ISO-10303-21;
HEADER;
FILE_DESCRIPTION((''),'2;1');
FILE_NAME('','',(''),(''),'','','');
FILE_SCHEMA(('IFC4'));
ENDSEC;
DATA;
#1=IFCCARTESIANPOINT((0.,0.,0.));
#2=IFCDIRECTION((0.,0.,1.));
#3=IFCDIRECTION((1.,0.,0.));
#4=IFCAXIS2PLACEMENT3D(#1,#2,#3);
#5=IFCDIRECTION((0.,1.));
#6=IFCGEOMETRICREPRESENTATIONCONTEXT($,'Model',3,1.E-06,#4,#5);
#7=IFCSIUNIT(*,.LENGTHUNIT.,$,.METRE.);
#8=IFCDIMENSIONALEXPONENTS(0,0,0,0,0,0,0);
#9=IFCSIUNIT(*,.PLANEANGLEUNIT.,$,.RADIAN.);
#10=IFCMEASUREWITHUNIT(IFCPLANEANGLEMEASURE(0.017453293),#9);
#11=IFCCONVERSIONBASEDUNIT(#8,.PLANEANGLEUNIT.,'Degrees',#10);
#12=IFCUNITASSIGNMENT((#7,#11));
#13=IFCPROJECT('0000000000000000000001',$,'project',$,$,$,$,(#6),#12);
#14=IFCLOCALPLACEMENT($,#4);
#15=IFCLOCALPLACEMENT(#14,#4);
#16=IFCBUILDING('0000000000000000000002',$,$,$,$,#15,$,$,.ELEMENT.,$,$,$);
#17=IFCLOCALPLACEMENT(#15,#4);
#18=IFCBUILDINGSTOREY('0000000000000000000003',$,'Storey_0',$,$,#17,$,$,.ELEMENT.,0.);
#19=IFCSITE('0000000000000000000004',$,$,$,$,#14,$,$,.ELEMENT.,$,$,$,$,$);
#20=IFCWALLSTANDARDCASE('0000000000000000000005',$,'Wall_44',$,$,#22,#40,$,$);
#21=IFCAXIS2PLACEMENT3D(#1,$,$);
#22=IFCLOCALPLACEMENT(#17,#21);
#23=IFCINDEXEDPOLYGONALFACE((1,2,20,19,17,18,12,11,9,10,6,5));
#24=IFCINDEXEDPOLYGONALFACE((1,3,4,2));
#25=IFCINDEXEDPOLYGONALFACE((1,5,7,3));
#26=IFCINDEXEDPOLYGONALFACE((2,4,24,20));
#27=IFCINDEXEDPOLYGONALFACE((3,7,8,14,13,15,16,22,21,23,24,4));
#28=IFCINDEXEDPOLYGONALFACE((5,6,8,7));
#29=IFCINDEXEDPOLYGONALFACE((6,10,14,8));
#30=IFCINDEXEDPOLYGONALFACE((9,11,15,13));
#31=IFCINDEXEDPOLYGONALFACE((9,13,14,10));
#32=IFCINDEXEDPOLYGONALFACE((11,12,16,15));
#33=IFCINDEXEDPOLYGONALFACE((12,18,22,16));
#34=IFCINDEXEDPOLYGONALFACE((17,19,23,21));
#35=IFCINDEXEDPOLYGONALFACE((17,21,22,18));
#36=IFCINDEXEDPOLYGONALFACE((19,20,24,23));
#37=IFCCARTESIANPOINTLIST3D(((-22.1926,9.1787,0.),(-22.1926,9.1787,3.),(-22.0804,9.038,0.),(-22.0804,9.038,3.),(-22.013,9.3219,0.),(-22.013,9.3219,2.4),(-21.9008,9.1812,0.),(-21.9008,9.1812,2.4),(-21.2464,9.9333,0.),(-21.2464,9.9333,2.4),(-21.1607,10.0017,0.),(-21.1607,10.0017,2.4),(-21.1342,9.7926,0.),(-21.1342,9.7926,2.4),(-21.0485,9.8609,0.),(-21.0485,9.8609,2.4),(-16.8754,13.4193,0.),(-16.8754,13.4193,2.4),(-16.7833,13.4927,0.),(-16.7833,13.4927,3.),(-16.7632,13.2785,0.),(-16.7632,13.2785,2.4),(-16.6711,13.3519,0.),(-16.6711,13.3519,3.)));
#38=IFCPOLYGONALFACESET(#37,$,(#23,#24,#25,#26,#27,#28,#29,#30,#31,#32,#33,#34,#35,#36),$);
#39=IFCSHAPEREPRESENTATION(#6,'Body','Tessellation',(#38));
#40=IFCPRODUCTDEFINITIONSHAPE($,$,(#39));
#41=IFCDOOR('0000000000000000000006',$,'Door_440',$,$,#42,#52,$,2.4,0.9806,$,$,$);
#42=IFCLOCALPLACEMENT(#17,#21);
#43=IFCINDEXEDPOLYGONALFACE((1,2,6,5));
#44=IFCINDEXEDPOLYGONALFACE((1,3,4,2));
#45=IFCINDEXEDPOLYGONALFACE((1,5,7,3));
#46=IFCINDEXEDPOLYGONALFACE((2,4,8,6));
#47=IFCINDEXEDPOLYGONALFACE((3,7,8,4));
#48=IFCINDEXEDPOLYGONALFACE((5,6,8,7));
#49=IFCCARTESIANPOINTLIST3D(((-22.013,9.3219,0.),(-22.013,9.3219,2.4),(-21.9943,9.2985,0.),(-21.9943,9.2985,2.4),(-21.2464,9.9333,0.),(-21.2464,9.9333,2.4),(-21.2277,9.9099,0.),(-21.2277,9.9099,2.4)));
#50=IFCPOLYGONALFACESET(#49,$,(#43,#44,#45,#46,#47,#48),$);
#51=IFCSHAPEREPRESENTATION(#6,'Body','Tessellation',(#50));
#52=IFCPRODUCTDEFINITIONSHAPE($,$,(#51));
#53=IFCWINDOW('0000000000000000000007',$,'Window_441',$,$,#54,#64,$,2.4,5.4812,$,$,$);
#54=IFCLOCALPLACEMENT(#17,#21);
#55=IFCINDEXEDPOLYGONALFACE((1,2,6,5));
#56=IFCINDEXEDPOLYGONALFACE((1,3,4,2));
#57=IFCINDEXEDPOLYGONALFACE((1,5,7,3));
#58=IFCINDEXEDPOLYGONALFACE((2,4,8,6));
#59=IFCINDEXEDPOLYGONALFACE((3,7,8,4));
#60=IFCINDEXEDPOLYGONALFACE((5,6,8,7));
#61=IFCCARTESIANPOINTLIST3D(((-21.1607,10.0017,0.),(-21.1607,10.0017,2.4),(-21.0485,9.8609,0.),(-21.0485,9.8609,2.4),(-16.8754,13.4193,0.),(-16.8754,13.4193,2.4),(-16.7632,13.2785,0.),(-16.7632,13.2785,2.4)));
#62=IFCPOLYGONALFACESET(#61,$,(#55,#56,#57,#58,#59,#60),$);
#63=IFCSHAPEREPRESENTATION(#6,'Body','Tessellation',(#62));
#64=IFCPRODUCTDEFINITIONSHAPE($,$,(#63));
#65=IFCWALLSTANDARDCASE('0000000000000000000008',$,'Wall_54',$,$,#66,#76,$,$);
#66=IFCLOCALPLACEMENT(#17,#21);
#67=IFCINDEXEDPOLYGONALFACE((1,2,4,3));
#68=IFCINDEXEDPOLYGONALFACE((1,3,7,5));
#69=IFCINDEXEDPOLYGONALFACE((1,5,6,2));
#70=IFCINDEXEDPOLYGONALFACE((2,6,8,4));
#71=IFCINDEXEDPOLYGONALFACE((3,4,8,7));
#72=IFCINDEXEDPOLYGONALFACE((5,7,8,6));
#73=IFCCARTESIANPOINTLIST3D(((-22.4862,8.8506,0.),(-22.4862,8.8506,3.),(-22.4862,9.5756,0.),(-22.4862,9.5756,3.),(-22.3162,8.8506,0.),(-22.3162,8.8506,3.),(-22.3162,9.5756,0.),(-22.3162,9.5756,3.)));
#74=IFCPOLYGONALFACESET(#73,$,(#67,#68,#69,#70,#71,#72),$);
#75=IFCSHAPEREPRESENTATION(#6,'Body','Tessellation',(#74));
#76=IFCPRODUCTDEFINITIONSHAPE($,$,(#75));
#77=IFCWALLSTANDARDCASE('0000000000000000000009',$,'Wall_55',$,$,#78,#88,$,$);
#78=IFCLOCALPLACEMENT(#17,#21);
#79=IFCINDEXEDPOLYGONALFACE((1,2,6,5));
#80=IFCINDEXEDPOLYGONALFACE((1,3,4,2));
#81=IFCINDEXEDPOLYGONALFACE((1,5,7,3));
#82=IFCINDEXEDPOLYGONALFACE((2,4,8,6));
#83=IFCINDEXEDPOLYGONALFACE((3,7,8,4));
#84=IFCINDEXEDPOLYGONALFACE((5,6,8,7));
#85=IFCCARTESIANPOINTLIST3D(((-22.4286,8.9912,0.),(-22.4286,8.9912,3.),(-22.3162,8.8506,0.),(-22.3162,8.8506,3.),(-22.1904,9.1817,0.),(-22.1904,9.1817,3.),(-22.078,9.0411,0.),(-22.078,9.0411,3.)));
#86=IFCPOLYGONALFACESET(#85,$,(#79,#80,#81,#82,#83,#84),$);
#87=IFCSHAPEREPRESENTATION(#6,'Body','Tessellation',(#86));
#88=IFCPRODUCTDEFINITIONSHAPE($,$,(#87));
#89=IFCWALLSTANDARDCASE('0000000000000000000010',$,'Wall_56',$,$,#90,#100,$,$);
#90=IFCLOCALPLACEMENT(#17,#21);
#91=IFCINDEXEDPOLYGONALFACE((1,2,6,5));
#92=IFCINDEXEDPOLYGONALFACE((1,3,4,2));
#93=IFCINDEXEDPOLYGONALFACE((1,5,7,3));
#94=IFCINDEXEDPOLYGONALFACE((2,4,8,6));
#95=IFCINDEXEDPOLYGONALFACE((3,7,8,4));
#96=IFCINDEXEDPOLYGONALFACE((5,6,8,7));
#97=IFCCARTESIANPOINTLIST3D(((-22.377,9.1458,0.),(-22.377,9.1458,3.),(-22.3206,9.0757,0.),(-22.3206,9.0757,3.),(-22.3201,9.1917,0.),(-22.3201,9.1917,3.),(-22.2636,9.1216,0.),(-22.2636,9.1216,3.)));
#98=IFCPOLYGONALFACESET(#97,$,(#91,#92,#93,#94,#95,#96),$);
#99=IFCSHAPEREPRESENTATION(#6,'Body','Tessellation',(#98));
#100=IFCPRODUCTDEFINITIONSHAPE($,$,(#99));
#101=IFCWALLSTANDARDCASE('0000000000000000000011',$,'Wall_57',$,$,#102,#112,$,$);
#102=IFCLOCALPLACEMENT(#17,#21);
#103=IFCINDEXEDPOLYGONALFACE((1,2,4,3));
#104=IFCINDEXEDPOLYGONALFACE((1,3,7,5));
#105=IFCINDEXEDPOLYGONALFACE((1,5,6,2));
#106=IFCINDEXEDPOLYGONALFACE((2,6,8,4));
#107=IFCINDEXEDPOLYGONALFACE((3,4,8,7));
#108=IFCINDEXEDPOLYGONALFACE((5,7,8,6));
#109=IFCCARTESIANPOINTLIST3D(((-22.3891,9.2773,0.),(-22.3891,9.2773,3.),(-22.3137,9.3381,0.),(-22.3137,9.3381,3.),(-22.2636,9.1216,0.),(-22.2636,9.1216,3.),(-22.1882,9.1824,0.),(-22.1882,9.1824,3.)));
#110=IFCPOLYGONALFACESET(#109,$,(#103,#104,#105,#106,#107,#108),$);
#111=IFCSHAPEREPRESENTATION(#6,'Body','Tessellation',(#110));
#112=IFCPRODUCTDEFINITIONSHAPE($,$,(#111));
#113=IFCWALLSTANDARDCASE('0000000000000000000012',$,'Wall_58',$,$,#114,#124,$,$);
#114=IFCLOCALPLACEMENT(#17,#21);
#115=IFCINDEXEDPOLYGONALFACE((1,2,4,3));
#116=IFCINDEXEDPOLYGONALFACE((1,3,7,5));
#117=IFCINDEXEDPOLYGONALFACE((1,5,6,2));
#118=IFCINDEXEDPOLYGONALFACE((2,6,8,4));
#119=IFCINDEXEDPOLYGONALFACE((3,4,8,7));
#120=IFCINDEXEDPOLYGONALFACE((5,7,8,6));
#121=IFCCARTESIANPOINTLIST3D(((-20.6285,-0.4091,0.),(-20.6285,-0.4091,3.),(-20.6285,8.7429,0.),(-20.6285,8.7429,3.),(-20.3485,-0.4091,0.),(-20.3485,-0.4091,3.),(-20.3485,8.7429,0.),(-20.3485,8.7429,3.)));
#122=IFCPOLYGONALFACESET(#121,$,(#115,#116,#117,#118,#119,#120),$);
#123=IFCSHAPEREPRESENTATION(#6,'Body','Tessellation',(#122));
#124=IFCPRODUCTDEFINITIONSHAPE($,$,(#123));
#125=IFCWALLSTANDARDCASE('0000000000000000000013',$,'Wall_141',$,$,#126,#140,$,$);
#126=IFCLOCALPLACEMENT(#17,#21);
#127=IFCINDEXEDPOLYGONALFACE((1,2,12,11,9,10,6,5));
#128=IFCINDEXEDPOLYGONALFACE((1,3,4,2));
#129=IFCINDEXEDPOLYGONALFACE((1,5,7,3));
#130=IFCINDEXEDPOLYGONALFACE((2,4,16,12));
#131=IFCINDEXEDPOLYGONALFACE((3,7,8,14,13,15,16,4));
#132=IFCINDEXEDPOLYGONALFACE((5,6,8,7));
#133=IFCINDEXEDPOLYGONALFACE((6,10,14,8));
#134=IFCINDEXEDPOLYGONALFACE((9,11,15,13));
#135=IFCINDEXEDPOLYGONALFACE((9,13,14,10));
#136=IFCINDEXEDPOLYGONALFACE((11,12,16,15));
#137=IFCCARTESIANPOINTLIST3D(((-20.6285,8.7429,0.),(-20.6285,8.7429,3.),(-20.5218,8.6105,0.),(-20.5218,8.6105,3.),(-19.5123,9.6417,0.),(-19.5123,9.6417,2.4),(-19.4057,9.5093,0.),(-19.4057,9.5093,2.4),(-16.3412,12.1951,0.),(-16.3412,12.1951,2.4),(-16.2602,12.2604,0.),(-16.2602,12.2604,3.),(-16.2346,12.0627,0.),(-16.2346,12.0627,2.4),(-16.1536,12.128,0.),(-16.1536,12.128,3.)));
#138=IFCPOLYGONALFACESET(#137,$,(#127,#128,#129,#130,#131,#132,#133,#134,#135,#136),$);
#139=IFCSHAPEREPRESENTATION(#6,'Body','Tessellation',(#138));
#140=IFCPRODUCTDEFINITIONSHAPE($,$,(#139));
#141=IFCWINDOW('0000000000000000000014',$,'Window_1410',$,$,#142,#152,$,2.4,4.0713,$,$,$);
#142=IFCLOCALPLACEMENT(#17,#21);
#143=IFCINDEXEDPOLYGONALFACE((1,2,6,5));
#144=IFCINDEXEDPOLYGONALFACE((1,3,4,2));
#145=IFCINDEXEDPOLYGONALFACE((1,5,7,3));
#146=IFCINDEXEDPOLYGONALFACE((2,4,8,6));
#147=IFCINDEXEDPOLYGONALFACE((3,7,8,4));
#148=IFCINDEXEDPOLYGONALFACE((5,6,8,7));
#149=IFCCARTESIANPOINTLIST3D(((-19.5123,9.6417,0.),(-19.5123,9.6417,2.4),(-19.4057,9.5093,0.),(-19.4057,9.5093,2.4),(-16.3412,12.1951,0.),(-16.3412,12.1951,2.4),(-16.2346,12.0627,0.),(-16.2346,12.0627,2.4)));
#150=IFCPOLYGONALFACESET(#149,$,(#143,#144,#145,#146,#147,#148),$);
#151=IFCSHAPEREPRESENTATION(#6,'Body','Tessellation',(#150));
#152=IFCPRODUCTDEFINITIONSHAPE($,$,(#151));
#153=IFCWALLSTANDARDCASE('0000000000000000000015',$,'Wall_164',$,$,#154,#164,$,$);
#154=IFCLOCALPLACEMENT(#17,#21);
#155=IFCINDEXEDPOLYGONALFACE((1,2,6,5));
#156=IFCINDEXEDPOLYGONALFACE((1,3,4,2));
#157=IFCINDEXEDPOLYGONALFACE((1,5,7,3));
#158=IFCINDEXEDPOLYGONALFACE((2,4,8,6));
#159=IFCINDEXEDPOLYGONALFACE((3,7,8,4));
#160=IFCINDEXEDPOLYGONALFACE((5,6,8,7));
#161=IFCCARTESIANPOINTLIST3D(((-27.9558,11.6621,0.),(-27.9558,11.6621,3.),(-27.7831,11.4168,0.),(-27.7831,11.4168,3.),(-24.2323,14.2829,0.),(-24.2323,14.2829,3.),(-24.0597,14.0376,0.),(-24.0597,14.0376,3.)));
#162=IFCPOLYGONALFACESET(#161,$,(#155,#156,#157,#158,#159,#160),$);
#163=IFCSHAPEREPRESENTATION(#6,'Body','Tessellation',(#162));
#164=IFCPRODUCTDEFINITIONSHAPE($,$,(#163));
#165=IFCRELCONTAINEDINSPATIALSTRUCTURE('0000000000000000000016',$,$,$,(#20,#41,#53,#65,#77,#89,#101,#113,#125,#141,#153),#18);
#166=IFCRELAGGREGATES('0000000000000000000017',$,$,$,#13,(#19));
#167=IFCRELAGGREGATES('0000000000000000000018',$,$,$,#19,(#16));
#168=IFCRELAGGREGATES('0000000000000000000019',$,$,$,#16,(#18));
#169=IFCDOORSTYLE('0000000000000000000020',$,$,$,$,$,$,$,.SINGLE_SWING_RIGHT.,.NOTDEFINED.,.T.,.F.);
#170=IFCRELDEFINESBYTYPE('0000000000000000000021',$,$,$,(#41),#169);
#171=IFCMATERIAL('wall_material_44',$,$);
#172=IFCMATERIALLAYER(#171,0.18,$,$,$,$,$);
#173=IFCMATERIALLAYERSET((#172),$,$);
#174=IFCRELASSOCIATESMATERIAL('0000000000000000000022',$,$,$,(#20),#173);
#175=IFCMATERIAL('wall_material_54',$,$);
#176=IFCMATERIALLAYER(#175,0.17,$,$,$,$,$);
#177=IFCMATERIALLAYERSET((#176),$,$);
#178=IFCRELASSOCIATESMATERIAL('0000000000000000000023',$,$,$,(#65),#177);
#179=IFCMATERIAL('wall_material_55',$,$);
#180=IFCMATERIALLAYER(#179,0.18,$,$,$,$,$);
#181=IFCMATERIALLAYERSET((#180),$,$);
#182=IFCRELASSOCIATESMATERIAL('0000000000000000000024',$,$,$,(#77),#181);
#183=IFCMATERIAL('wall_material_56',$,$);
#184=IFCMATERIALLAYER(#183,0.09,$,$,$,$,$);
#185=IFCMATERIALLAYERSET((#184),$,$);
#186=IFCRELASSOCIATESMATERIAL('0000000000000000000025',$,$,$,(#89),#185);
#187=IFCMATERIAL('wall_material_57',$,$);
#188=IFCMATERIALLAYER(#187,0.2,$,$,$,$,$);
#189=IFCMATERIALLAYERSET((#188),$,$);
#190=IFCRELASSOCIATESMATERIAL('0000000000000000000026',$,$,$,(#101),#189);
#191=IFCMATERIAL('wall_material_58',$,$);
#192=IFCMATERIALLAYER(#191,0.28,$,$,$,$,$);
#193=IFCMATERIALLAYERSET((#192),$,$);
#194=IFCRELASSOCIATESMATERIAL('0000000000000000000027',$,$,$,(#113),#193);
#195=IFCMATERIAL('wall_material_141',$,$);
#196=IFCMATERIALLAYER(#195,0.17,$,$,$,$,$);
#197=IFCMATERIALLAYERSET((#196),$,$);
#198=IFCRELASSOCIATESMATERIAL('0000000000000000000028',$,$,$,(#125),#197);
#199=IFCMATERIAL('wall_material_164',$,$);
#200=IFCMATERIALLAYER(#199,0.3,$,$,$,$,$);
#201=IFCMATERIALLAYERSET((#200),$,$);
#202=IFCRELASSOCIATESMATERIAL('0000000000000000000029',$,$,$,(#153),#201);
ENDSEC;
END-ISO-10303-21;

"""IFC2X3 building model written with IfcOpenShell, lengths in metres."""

from ifc_helpers import new_model, entity, si_unit, converted_unit, direction, frame, frame_2d, origin_with_axes, place, context, project, spatial, polyline, rectangle, outline, extrude, material, layer, layer_set, layer_usage, type_object, element, fill, save


model = new_model("IFC2X3")

# Units and contexts
model_context = context("Model", 3, precision=1e-06, world=origin_with_axes(), true_north=direction((0.0, 1.0)))
ifc_project = project(units=[si_unit("LENGTHUNIT", "METRE"), converted_unit("PLANEANGLEUNIT", "Degrees", entity("IfcPlaneAngleMeasure", 0.017453293), si_unit("PLANEANGLEUNIT", "RADIAN"), dimensions=[0, 0, 0, 0, 0, 0, 0])], contexts=[model_context])

# Site, building, storey
site_placement = place(None, origin_with_axes())
site = spatial("IfcSite", under=ifc_project, at=site_placement, CompositionType="ELEMENT")
building_placement = place(site_placement, origin_with_axes())
building = spatial("IfcBuilding", under=site, at=building_placement, CompositionType="ELEMENT")
storey_placement = place(building_placement, origin_with_axes())
storey = spatial("IfcBuildingStorey", under=building, at=storey_placement, Name="Storey_0", CompositionType="ELEMENT", Elevation=0.0)

# Wall, openings, door, window
ifc_material_1 = material(Name="wall_material_44")
ifc_layer_1 = layer(ifc_material_1, 0.18)
ifc_layer_set_1 = layer_set([ifc_layer_1])
ifc_layer_usage_1 = layer_usage(ifc_layer_set_1, "AXIS2", "POSITIVE", 0.0)
wall_1_placement = place(storey_placement, frame((-22.0804, 9.038, 0.0), z_axis=(0.0, 0.0, 1.0), x_axis=(0.781817, 0.623508, 0.0)))
wall_1 = element("IfcWallStandardCase", 1, at=wall_1_placement, inside=storey, material=ifc_layer_usage_1, Name="Wall_44", context=model_context, shape_type="SweptSolid", body=[
    extrude(outline(polyline([(0.0, 0.18), (6.9189, 0.18), (6.9189, 0.0), (0.0, 0.0), (0.0, 0.18)])), origin_with_axes(), (0.0, 0.0, 1.0), 3.0),
])
opening_1_placement = place(wall_1_placement, frame((0.2297, 0.18, 0.0), z_axis=(0.0, 0.0, 1.0), x_axis=(1.0, 0.0, 0.0)))
opening_1 = element("IfcOpeningElement", 2, at=opening_1_placement, cuts=wall_1, context=model_context, shape_type="SweptSolid", body=[
    extrude(rectangle(XDim=0.9806, YDim=2.4, at=frame_2d((1.2, -0.4903), x_axis=(0.0, 1.0))), frame((0.0, 0.01, 0.0), z_axis=(0.0, -1.0, 0.0), x_axis=(0.0, 0.0, 1.0)), (0.0, 0.0, 1.0), 0.2),
])
opening_2_placement = place(wall_1_placement, frame((1.3199, 0.18, 0.0), z_axis=(0.0, 0.0, 1.0), x_axis=(1.0, 0.0, 0.0)))
opening_2 = element("IfcOpeningElement", 3, at=opening_2_placement, cuts=wall_1, context=model_context, shape_type="SweptSolid", body=[
    extrude(rectangle(XDim=5.4812, YDim=2.4, at=frame_2d((1.2, -2.7406), x_axis=(0.0, 1.0))), frame((0.0, 0.01, 0.0), z_axis=(0.0, -1.0, 0.0), x_axis=(0.0, 0.0, 1.0)), (0.0, 0.0, 1.0), 0.2),
])
door_style_1 = type_object("IfcDoorStyle", ConstructionType="NOTDEFINED", OperationType="SINGLE_SWING_RIGHT", ParameterTakesPrecedence=True, Sizeable=False)
door_1_placement = place(storey_placement, origin_with_axes())
door_1 = element("IfcDoor", 4, at=door_1_placement, inside=storey, type_object=door_style_1, Name="Door_440", OverallHeight=2.4, OverallWidth=0.9806, context=model_context, shape_type="SweptSolid", body=[
    extrude(outline(polyline([(-22.013, 9.3219), (-21.2464, 9.9333), (-21.2277, 9.9099), (-21.9943, 9.2985), (-22.013, 9.3219)])), origin_with_axes(), (0.0, 0.0, 1.0), 2.4),
])
fill(opening_1, door_1)
window_1_placement = place(storey_placement, origin_with_axes())
window_1 = element("IfcWindow", 5, at=window_1_placement, inside=storey, Name="Window_441", OverallHeight=2.4, OverallWidth=5.4812, context=model_context, shape_type="SweptSolid", body=[
    extrude(outline(polyline([(-21.1607, 10.0017), (-16.8754, 13.4193), (-16.7632, 13.2785), (-21.0485, 9.8609), (-21.1607, 10.0017)])), origin_with_axes(), (0.0, 0.0, 1.0), 2.4),
])
fill(opening_2, window_1)

# Walls
ifc_material_2 = material(Name="wall_material_54")
ifc_layer_2 = layer(ifc_material_2, 0.17)
ifc_layer_set_2 = layer_set([ifc_layer_2])
ifc_layer_usage_2 = layer_usage(ifc_layer_set_2, "AXIS2", "NEGATIVE", 0.0)
wall_2_placement = place(storey_placement, frame((-22.3162, 9.5756, 0.0), z_axis=(0.0, 0.0, 1.0), x_axis=(0.0, -1.0, 0.0)))
element("IfcWallStandardCase", 6, at=wall_2_placement, inside=storey, material=ifc_layer_usage_2, Name="Wall_54", context=model_context, shape_type="SweptSolid", body=[
    extrude(outline(polyline([(0.0, 0.0), (0.725, 0.0), (0.725, -0.17), (0.0, -0.17), (0.0, 0.0)])), origin_with_axes(), (0.0, 0.0, 1.0), 3.0),
])
ifc_material_3 = material(Name="wall_material_55")
ifc_layer_3 = layer(ifc_material_3, 0.18)
ifc_layer_set_3 = layer_set([ifc_layer_3])
ifc_layer_usage_3 = layer_usage(ifc_layer_set_3, "AXIS2", "POSITIVE", 0.0)
wall_3_placement = place(storey_placement, frame((-22.3162, 8.8506, 0.0), z_axis=(0.0, 0.0, 1.0), x_axis=(0.781037, 0.624485, 0.0)))
element("IfcWallStandardCase", 7, at=wall_3_placement, inside=storey, material=ifc_layer_usage_3, Name="Wall_55", context=model_context, shape_type="SweptSolid", body=[
    extrude(outline(polyline([(0.0, 0.18), (0.3049, 0.18), (0.3049, 0.0), (0.0, 0.0), (0.0, 0.18)])), origin_with_axes(), (0.0, 0.0, 1.0), 3.0),
])
ifc_material_4 = material(Name="wall_material_56")
ifc_layer_4 = layer(ifc_material_4, 0.09)
ifc_layer_set_4 = layer_set([ifc_layer_4])
ifc_layer_usage_4 = layer_usage(ifc_layer_set_4, "AXIS2", "POSITIVE", 0.0)
wall_4_placement = place(storey_placement, frame((-22.3206, 9.0757, 0.0), z_axis=(0.0, 0.0, 1.0), x_axis=(0.778706, 0.627389, 0.0)))
element("IfcWallStandardCase", 8, at=wall_4_placement, inside=storey, material=ifc_layer_usage_4, Name="Wall_56", context=model_context, shape_type="SweptSolid", body=[
    extrude(outline(polyline([(0.0, 0.09), (0.0731, 0.09), (0.0731, 0.0), (0.0, 0.0), (0.0, 0.09)])), origin_with_axes(), (0.0, 0.0, 1.0), 3.0),
])
ifc_material_5 = material(Name="wall_material_57")
ifc_layer_5 = layer(ifc_material_5, 0.2)
ifc_layer_set_5 = layer_set([ifc_layer_5])
ifc_layer_usage_5 = layer_usage(ifc_layer_set_5, "AXIS2", "POSITIVE", 0.0)
wall_5_placement = place(storey_placement, frame((-22.2636, 9.1216, 0.0), z_axis=(0.0, 0.0, 1.0), x_axis=(0.778706, 0.627389, 0.0)))
element("IfcWallStandardCase", 9, at=wall_5_placement, inside=storey, material=ifc_layer_usage_5, Name="Wall_57", context=model_context, shape_type="SweptSolid", body=[
    extrude(outline(polyline([(0.0, 0.2), (0.0969, 0.2), (0.0969, 0.0), (0.0, 0.0), (0.0, 0.2)])), origin_with_axes(), (0.0, 0.0, 1.0), 3.0),
])
ifc_material_6 = material(Name="wall_material_58")
ifc_layer_6 = layer(ifc_material_6, 0.28)
ifc_layer_set_6 = layer_set([ifc_layer_6])
ifc_layer_usage_6 = layer_usage(ifc_layer_set_6, "AXIS2", "POSITIVE", 0.0)
wall_6_placement = place(storey_placement, frame((-20.6285, 8.7429, 0.0), z_axis=(0.0, 0.0, 1.0), x_axis=(0.0, -1.0, 0.0)))
element("IfcWallStandardCase", 10, at=wall_6_placement, inside=storey, material=ifc_layer_usage_6, Name="Wall_58", context=model_context, shape_type="SweptSolid", body=[
    extrude(outline(polyline([(0.0, 0.28), (9.1519, 0.28), (9.1519, 0.0), (0.0, 0.0), (0.0, 0.28)])), origin_with_axes(), (0.0, 0.0, 1.0), 3.0),
])

# Wall, opening, window
ifc_material_7 = material(Name="wall_material_141")
ifc_layer_7 = layer(ifc_material_7, 0.17)
ifc_layer_set_7 = layer_set([ifc_layer_7])
ifc_layer_usage_7 = layer_usage(ifc_layer_set_7, "AXIS2", "NEGATIVE", 0.0)
wall_7_placement = place(storey_placement, frame((-20.6285, 8.7429, 0.0), z_axis=(0.0, 0.0, 1.0), x_axis=(0.778876, 0.627177, 0.0)))
wall_7 = element("IfcWallStandardCase", 11, at=wall_7_placement, inside=storey, material=ifc_layer_usage_7, Name="Wall_141", context=model_context, shape_type="SweptSolid", body=[
    extrude(outline(polyline([(0.0, 0.0), (5.6085, 0.0), (5.6085, -0.17), (0.0, -0.17), (0.0, 0.0)])), origin_with_axes(), (0.0, 0.0, 1.0), 3.0),
])
opening_3_placement = place(wall_7_placement, frame((1.4331, 0.0, 0.0), z_axis=(0.0, 0.0, 1.0), x_axis=(1.0, 0.0, 0.0)))
opening_3 = element("IfcOpeningElement", 12, at=opening_3_placement, cuts=wall_7, context=model_context, shape_type="SweptSolid", body=[
    extrude(rectangle(XDim=4.0713, YDim=2.4, at=frame_2d((1.2, -2.0357), x_axis=(0.0, 1.0))), frame((0.0, 0.01, 0.0), z_axis=(0.0, -1.0, 0.0), x_axis=(0.0, 0.0, 1.0)), (0.0, 0.0, 1.0), 0.19),
])
window_2_placement = place(storey_placement, origin_with_axes())
window_2 = element("IfcWindow", 13, at=window_2_placement, inside=storey, Name="Window_1410", OverallHeight=2.4, OverallWidth=4.0713, context=model_context, shape_type="SweptSolid", body=[
    extrude(outline(polyline([(-19.5123, 9.6417), (-16.3412, 12.1951), (-16.2346, 12.0627), (-19.4057, 9.5093), (-19.5123, 9.6417)])), origin_with_axes(), (0.0, 0.0, 1.0), 2.4),
])
fill(opening_3, window_2)

# Wall
ifc_material_8 = material(Name="wall_material_164")
ifc_layer_8 = layer(ifc_material_8, 0.3)
ifc_layer_set_8 = layer_set([ifc_layer_8])
ifc_layer_usage_8 = layer_usage(ifc_layer_set_8, "AXIS2", "NEGATIVE", 0.0)
wall_8_placement = place(storey_placement, frame((-27.9558, 11.6621, 0.0), z_axis=(0.0, 0.0, 1.0), x_axis=(0.817748, 0.575576, 0.0)))
element("IfcWallStandardCase", 14, at=wall_8_placement, inside=storey, material=ifc_layer_usage_8, Name="Wall_164", context=model_context, shape_type="SweptSolid", body=[
    extrude(outline(polyline([(0.0, 0.0), (4.5533, 0.0), (4.5533, -0.3), (0.0, -0.3), (0.0, 0.0)])), origin_with_axes(), (0.0, 0.0, 1.0), 3.0),
])

save(model, "model.ifc")
